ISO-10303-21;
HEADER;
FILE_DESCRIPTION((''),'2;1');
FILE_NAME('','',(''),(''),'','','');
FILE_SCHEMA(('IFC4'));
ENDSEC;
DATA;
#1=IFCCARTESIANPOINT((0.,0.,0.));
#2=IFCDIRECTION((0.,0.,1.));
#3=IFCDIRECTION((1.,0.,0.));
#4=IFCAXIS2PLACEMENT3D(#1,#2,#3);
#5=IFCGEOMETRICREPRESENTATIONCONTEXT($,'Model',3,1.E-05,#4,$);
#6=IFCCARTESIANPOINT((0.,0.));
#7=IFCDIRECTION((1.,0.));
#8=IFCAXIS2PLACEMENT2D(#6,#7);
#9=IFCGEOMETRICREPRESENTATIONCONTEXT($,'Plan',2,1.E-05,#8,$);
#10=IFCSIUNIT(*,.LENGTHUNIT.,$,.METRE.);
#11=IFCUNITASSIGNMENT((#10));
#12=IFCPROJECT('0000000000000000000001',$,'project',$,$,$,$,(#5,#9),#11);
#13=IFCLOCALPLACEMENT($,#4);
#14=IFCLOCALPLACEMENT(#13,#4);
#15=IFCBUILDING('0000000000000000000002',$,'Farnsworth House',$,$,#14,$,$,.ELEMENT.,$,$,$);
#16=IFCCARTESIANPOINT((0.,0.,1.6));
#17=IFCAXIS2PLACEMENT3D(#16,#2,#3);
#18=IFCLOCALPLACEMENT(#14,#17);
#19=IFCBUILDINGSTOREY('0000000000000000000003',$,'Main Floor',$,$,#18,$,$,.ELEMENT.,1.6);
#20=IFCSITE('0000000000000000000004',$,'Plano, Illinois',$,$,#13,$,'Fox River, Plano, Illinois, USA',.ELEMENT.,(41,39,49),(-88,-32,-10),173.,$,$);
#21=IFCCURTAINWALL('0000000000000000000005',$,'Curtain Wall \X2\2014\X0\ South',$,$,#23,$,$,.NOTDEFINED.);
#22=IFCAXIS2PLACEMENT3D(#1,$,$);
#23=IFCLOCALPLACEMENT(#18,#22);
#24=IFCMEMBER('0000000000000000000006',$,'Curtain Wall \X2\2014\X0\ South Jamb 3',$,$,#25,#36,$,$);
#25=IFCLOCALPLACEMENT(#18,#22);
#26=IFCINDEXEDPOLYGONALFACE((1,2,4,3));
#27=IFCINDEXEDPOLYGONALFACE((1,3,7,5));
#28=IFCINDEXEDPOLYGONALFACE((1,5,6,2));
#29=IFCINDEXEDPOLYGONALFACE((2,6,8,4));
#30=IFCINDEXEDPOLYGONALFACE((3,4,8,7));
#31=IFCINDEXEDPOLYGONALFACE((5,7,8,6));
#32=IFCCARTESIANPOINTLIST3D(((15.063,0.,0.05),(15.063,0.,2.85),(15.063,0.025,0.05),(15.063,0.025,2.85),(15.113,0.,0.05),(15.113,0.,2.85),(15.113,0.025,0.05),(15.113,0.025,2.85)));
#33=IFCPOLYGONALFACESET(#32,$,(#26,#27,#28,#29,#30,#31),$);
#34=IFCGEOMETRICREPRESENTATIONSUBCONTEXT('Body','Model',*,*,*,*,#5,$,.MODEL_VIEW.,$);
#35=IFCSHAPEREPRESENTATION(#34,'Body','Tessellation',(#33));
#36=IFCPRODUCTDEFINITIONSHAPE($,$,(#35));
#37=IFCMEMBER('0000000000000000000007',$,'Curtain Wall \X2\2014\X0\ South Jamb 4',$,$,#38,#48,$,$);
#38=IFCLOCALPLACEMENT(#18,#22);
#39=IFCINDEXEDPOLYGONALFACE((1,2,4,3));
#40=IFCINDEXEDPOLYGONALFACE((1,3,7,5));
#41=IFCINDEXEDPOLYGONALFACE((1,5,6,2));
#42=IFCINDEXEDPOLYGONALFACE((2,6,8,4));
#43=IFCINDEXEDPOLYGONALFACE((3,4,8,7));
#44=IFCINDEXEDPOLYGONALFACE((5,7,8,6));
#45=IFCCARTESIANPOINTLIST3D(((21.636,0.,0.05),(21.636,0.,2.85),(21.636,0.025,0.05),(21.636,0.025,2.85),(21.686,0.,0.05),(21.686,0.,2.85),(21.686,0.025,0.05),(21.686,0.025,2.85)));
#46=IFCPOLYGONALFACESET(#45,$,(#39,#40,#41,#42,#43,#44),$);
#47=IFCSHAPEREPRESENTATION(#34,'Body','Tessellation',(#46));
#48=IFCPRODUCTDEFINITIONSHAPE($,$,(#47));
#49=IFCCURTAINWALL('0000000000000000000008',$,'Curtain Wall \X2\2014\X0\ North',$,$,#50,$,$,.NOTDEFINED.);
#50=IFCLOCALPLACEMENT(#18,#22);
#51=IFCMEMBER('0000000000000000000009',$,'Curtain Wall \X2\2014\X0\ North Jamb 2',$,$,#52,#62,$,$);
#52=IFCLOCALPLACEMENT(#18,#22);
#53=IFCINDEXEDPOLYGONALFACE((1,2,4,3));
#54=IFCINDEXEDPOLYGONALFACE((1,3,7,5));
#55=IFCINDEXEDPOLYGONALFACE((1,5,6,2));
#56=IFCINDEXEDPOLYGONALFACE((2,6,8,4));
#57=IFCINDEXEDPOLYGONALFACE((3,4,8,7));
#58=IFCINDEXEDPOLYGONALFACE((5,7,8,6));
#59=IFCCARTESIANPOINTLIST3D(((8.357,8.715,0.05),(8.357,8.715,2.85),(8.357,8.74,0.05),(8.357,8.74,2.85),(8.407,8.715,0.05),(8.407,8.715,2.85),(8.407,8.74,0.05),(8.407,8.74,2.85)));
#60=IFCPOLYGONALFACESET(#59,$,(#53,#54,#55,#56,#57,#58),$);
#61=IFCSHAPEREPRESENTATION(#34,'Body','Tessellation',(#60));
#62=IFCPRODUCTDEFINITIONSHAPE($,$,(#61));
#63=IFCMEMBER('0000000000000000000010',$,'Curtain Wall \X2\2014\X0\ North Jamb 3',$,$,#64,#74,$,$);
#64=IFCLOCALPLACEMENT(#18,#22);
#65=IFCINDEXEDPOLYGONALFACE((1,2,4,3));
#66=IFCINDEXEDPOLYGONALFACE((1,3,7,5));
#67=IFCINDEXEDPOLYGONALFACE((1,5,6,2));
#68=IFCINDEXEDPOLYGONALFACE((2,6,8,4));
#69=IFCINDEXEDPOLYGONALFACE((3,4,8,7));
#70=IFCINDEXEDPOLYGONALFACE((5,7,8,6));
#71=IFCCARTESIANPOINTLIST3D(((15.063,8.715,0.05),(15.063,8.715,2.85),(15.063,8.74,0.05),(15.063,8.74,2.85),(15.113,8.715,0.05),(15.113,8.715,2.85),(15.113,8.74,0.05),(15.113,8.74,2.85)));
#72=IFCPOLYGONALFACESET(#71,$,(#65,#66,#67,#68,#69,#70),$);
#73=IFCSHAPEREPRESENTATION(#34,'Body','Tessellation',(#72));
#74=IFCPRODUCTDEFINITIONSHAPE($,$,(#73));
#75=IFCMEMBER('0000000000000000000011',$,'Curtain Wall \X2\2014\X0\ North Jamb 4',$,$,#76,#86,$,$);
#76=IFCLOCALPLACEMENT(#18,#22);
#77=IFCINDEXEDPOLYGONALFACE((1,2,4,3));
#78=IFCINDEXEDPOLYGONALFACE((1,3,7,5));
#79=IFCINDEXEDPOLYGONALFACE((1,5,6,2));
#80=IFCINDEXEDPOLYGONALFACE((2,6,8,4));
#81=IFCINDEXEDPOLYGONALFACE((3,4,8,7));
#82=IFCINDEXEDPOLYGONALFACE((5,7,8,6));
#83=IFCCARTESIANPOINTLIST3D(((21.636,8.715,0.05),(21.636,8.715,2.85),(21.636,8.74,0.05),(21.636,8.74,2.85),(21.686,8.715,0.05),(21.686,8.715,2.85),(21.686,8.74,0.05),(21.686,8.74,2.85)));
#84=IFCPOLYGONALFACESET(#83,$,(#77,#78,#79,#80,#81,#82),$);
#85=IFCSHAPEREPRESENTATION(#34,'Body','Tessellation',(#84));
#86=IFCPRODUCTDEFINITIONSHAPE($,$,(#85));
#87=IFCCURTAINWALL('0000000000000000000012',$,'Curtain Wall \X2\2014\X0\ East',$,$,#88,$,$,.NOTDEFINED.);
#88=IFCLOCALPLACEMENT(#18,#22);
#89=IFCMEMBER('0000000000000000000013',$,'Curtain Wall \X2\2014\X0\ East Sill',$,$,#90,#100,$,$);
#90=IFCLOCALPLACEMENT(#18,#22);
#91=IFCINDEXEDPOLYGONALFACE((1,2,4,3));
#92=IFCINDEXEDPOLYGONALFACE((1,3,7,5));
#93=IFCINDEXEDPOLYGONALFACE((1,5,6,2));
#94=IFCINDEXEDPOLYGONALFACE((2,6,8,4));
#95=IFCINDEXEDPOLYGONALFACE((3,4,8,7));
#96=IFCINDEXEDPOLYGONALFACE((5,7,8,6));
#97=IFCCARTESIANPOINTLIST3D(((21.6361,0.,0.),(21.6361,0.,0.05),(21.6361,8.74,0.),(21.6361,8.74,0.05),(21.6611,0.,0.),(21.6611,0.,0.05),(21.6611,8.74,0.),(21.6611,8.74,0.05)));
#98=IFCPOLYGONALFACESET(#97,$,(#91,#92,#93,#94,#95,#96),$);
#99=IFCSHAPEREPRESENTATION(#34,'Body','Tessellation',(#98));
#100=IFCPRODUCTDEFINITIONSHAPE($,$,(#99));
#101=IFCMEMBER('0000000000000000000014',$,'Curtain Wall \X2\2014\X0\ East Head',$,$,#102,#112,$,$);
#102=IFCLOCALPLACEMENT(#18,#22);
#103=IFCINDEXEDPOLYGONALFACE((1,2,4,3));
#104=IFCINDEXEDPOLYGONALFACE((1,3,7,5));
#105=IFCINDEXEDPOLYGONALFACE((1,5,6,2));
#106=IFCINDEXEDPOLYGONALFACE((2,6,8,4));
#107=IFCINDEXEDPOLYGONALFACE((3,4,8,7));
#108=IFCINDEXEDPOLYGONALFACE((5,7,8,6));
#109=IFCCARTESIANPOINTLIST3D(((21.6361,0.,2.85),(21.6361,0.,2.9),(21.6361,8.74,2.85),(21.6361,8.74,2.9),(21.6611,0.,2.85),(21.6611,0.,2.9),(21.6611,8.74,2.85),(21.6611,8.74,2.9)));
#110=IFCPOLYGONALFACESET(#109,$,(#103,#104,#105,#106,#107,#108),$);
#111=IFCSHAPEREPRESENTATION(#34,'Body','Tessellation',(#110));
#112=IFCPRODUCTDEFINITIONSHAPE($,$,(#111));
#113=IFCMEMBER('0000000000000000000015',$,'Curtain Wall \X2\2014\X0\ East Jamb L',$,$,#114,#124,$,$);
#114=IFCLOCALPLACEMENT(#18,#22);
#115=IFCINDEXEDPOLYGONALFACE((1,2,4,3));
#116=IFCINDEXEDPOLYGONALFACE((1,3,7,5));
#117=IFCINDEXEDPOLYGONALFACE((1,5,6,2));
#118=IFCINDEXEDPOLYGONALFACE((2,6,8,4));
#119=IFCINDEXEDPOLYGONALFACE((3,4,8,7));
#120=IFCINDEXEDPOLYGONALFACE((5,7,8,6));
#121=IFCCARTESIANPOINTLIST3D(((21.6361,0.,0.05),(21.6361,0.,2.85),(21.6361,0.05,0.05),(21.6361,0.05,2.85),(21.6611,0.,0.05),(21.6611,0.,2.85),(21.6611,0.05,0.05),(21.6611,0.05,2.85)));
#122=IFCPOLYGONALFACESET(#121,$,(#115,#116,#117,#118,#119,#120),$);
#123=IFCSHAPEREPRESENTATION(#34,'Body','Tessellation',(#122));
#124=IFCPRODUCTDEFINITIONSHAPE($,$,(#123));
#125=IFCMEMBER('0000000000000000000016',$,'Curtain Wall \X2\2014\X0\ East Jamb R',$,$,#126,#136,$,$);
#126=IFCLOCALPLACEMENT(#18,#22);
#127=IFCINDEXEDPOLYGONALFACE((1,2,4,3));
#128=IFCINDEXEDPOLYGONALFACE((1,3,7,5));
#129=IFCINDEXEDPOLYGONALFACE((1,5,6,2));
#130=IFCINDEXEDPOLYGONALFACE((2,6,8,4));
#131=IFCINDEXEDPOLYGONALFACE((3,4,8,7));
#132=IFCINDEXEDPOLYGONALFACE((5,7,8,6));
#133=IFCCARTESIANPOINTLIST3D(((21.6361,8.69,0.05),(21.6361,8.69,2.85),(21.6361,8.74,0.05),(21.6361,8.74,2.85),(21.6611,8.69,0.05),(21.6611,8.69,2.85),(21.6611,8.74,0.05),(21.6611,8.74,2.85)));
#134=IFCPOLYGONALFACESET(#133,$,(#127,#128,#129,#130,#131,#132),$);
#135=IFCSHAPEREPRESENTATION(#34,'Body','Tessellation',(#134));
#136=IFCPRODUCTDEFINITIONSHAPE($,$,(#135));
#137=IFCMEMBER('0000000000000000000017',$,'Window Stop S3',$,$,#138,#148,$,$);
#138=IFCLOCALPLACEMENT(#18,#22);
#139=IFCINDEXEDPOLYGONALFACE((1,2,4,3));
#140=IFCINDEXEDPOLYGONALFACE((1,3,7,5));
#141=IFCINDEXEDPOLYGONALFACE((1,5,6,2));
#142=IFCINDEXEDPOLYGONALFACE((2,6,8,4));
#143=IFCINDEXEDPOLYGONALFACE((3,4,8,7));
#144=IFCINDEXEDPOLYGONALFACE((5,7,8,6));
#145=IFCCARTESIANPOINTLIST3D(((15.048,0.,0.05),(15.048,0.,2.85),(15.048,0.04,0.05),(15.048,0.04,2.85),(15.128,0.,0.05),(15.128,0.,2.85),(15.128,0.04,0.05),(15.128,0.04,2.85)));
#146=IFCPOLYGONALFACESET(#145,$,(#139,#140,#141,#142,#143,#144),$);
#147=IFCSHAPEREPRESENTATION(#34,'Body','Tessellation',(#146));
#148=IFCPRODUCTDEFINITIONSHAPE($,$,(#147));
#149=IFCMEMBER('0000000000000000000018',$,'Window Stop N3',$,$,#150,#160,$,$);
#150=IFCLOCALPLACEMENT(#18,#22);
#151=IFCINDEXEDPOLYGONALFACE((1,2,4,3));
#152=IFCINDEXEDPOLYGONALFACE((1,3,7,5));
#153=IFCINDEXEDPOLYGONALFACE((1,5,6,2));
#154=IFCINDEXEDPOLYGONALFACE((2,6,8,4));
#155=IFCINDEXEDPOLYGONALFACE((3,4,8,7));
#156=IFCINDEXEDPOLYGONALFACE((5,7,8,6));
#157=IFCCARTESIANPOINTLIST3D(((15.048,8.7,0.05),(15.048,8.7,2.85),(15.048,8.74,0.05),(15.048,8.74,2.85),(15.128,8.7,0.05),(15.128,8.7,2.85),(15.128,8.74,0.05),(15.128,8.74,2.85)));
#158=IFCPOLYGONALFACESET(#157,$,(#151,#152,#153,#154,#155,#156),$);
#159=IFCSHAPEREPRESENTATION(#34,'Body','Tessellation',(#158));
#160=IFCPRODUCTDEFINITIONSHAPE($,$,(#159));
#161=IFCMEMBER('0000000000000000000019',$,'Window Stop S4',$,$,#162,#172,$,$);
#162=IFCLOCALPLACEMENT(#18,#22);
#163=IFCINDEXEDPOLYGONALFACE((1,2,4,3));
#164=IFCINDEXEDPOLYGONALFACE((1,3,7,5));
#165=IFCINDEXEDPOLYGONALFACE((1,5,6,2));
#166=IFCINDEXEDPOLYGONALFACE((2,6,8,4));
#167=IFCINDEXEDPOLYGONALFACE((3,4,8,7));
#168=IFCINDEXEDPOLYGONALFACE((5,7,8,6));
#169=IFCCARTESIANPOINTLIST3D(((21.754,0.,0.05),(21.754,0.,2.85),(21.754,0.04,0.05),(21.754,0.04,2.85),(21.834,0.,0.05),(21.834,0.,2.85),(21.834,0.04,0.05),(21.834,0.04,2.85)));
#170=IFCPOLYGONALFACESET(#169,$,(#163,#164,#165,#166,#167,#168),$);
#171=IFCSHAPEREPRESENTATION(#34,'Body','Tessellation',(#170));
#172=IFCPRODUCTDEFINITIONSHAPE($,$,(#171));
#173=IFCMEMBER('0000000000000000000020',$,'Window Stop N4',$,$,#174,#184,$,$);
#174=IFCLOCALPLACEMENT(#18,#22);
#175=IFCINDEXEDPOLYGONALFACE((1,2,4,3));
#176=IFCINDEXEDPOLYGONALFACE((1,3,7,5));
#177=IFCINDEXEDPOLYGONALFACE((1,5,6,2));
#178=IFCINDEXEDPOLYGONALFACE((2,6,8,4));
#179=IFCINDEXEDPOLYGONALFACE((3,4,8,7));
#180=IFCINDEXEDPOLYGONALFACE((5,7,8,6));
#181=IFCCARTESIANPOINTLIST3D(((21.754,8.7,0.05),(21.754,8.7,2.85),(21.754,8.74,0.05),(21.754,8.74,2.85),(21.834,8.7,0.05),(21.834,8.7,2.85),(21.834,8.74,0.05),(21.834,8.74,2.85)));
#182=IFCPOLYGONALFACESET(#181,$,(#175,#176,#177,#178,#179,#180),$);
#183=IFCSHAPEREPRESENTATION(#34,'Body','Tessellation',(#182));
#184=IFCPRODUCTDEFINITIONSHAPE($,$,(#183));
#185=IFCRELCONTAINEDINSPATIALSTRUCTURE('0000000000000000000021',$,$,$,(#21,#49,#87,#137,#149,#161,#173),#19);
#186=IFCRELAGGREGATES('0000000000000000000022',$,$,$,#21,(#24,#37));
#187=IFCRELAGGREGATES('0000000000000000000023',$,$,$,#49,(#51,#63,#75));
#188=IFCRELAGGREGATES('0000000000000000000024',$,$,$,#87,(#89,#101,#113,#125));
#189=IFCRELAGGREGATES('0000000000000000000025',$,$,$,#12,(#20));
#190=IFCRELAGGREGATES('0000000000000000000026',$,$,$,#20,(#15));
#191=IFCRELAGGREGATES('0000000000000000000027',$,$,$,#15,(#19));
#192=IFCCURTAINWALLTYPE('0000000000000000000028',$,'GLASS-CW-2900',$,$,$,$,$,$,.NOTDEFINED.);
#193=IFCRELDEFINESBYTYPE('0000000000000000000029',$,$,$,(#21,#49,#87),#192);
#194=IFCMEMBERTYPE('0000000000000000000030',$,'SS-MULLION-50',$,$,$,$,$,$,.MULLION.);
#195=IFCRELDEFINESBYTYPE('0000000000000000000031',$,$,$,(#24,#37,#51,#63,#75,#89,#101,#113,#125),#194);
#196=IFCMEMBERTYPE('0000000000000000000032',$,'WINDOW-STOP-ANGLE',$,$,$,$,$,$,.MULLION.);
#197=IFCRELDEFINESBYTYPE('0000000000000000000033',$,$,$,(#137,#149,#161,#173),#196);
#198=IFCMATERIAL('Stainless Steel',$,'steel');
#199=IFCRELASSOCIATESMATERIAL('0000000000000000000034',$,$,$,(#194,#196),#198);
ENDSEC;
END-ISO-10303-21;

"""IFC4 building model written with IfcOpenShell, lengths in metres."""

from ifc_helpers import new_model, si_unit, frame, origin_with_axes, origin_2d_with_axis, place, context, subcontext, project, spatial, rectangle, extrude, material, type_object, element, aggregate, save


model = new_model("IFC4")

# Units and contexts
model_context = context("Model", 3, precision=1e-05, world=origin_with_axes())
plan_context = context("Plan", 2, precision=1e-05, world=origin_2d_with_axis())
body_context = subcontext(model_context, "Body", "Model", "MODEL_VIEW")
ifc_project = project(units=[si_unit("LENGTHUNIT", "METRE")], contexts=[model_context, plan_context])

# Site, building, storey
site_placement = place(None, origin_with_axes())
site = spatial("IfcSite", under=ifc_project, at=site_placement, Name="Plano, Illinois", LongName="Fox River, Plano, Illinois, USA", CompositionType="ELEMENT", RefLatitude=(41, 39, 49), RefLongitude=(-88, -32, -10), RefElevation=173.0)
building_placement = place(site_placement, origin_with_axes())
building = spatial("IfcBuilding", under=site, at=building_placement, Name="Farnsworth House", CompositionType="ELEMENT")
storey_placement = place(building_placement, frame((0.0, 0.0, 1.6), z_axis=(0.0, 0.0, 1.0), x_axis=(1.0, 0.0, 0.0)))
storey = spatial("IfcBuildingStorey", under=building, at=storey_placement, Name="Main Floor", CompositionType="ELEMENT", Elevation=1.6)

# Curtain walls, members
curtain_wall_type = type_object("IfcCurtainWallType", Name="GLASS-CW-2900", PredefinedType="NOTDEFINED")
curtain_wall_1_placement = place(storey_placement, frame((1.7839, 0.0, 0.0), z_axis=(0.0, 0.0, 1.0), x_axis=(1.0, 0.0, 0.0)))
curtain_wall_1 = element("IfcCurtainWall", 1, at=curtain_wall_1_placement, inside=storey, type_object=curtain_wall_type, Name="Curtain Wall — South", PredefinedType="NOTDEFINED")
ifc_material_1 = material(Name="Stainless Steel", Category="steel")
member_type_1 = type_object("IfcMemberType", Name="SS-MULLION-50", PredefinedType="MULLION", material=ifc_material_1)
member_1_placement = place(curtain_wall_1_placement, frame((13.279, 0.0, 0.05), z_axis=(0.0, 0.0, 1.0), x_axis=(1.0, 0.0, 0.0)))
member_1 = element("IfcMember", 2, at=member_1_placement, type_object=member_type_1, Name="Curtain Wall — South Jamb 3", context=body_context, shape_type="SweptSolid", body=[
    extrude(rectangle(XDim=0.05, YDim=0.025, at=origin_2d_with_axis()), frame((0.025, 0.0125, 0.0), z_axis=(0.0, 0.0, 1.0), x_axis=(1.0, 0.0, 0.0)), (0.0, 0.0, 1.0), 2.8),
])
member_2_placement = place(curtain_wall_1_placement, frame((19.8521, 0.0, 0.05), z_axis=(0.0, 0.0, 1.0), x_axis=(1.0, 0.0, 0.0)))
member_2 = element("IfcMember", 3, at=member_2_placement, type_object=member_type_1, Name="Curtain Wall — South Jamb 4", context=body_context, shape_type="SweptSolid", body=[
    extrude(rectangle(XDim=0.05, YDim=0.025, at=origin_2d_with_axis()), frame((0.025, 0.0125, 0.0), z_axis=(0.0, 0.0, 1.0), x_axis=(1.0, 0.0, 0.0)), (0.0, 0.0, 1.0), 2.8),
])
curtain_wall_2_placement = place(storey_placement, frame((1.7839, 8.715, 0.0), z_axis=(0.0, 0.0, 1.0), x_axis=(1.0, 0.0, 0.0)))
curtain_wall_2 = element("IfcCurtainWall", 4, at=curtain_wall_2_placement, inside=storey, type_object=curtain_wall_type, Name="Curtain Wall — North", PredefinedType="NOTDEFINED")
member_3_placement = place(curtain_wall_2_placement, frame((6.573, 0.0, 0.05), z_axis=(0.0, 0.0, 1.0), x_axis=(1.0, 0.0, 0.0)))
member_3 = element("IfcMember", 5, at=member_3_placement, type_object=member_type_1, Name="Curtain Wall — North Jamb 2", context=body_context, shape_type="SweptSolid", body=[
    extrude(rectangle(XDim=0.05, YDim=0.025, at=origin_2d_with_axis()), frame((0.025, 0.0125, 0.0), z_axis=(0.0, 0.0, 1.0), x_axis=(1.0, 0.0, 0.0)), (0.0, 0.0, 1.0), 2.8),
])
member_4_placement = place(curtain_wall_2_placement, frame((13.279, 0.0, 0.05), z_axis=(0.0, 0.0, 1.0), x_axis=(1.0, 0.0, 0.0)))
member_4 = element("IfcMember", 6, at=member_4_placement, type_object=member_type_1, Name="Curtain Wall — North Jamb 3", context=body_context, shape_type="SweptSolid", body=[
    extrude(rectangle(XDim=0.05, YDim=0.025, at=origin_2d_with_axis()), frame((0.025, 0.0125, 0.0), z_axis=(0.0, 0.0, 1.0), x_axis=(1.0, 0.0, 0.0)), (0.0, 0.0, 1.0), 2.8),
])
member_5_placement = place(curtain_wall_2_placement, frame((19.8521, 0.0, 0.05), z_axis=(0.0, 0.0, 1.0), x_axis=(1.0, 0.0, 0.0)))
member_5 = element("IfcMember", 7, at=member_5_placement, type_object=member_type_1, Name="Curtain Wall — North Jamb 4", context=body_context, shape_type="SweptSolid", body=[
    extrude(rectangle(XDim=0.05, YDim=0.025, at=origin_2d_with_axis()), frame((0.025, 0.0125, 0.0), z_axis=(0.0, 0.0, 1.0), x_axis=(1.0, 0.0, 0.0)), (0.0, 0.0, 1.0), 2.8),
])
curtain_wall_3_placement = place(storey_placement, frame((21.6611, 0.0, 0.0), z_axis=(0.0, 0.0, 1.0), x_axis=(0.0, 1.0, 0.0)))
curtain_wall_3 = element("IfcCurtainWall", 8, at=curtain_wall_3_placement, inside=storey, type_object=curtain_wall_type, Name="Curtain Wall — East", PredefinedType="NOTDEFINED")
member_6_placement = place(curtain_wall_3_placement, origin_with_axes())
member_6 = element("IfcMember", 9, at=member_6_placement, type_object=member_type_1, Name="Curtain Wall — East Sill", context=body_context, shape_type="SweptSolid", body=[
    extrude(rectangle(XDim=8.74, YDim=0.025, at=origin_2d_with_axis()), frame((4.37, 0.0125, 0.0), z_axis=(0.0, 0.0, 1.0), x_axis=(1.0, 0.0, 0.0)), (0.0, 0.0, 1.0), 0.05),
])
member_7_placement = place(curtain_wall_3_placement, frame((0.0, 0.0, 2.85), z_axis=(0.0, 0.0, 1.0), x_axis=(1.0, 0.0, 0.0)))
member_7 = element("IfcMember", 10, at=member_7_placement, type_object=member_type_1, Name="Curtain Wall — East Head", context=body_context, shape_type="SweptSolid", body=[
    extrude(rectangle(XDim=8.74, YDim=0.025, at=origin_2d_with_axis()), frame((4.37, 0.0125, 0.0), z_axis=(0.0, 0.0, 1.0), x_axis=(1.0, 0.0, 0.0)), (0.0, 0.0, 1.0), 0.05),
])
member_8_placement = place(curtain_wall_3_placement, frame((0.0, 0.0, 0.05), z_axis=(0.0, 0.0, 1.0), x_axis=(1.0, 0.0, 0.0)))
member_8 = element("IfcMember", 11, at=member_8_placement, type_object=member_type_1, Name="Curtain Wall — East Jamb L", context=body_context, shape_type="SweptSolid", body=[
    extrude(rectangle(XDim=0.05, YDim=0.025, at=origin_2d_with_axis()), frame((0.025, 0.0125, 0.0), z_axis=(0.0, 0.0, 1.0), x_axis=(1.0, 0.0, 0.0)), (0.0, 0.0, 1.0), 2.8),
])
member_9_placement = place(curtain_wall_3_placement, frame((8.69, 0.0, 0.05), z_axis=(0.0, 0.0, 1.0), x_axis=(1.0, 0.0, 0.0)))
member_9 = element("IfcMember", 12, at=member_9_placement, type_object=member_type_1, Name="Curtain Wall — East Jamb R", context=body_context, shape_type="SweptSolid", body=[
    extrude(rectangle(XDim=0.05, YDim=0.025, at=origin_2d_with_axis()), frame((0.025, 0.0125, 0.0), z_axis=(0.0, 0.0, 1.0), x_axis=(1.0, 0.0, 0.0)), (0.0, 0.0, 1.0), 2.8),
])

# Members
member_type_2 = type_object("IfcMemberType", Name="WINDOW-STOP-ANGLE", PredefinedType="MULLION", material=ifc_material_1)
for number, where, z_axis, x_axis, name in (
    (13, (15.048, 0.0, 0.05), (0.0, 0.0, 1.0), (1.0, 0.0, 0.0), "Window Stop S3"),
    (14, (15.048, 8.7, 0.05), (0.0, 0.0, 1.0), (1.0, 0.0, 0.0), "Window Stop N3"),
    (15, (21.754, 0.0, 0.05), (0.0, 0.0, 1.0), (1.0, 0.0, 0.0), "Window Stop S4"),
    (16, (21.754, 8.7, 0.05), (0.0, 0.0, 1.0), (1.0, 0.0, 0.0), "Window Stop N4"),
):
    element("IfcMember", number, at=place(storey_placement, frame(where, z_axis=z_axis, x_axis=x_axis)), inside=storey, type_object=member_type_2, Name=name, context=body_context, shape_type="SweptSolid", body=[
        extrude(rectangle(XDim=0.08, YDim=0.04, at=origin_2d_with_axis()), frame((0.04, 0.02, 0.0), z_axis=(0.0, 0.0, 1.0), x_axis=(1.0, 0.0, 0.0)), (0.0, 0.0, 1.0), 2.8),
    ])

aggregate(curtain_wall_1, [member_1, member_2])
aggregate(curtain_wall_2, [member_3, member_4, member_5])
aggregate(curtain_wall_3, [member_6, member_7, member_8, member_9])

save(model, "model.ifc")
